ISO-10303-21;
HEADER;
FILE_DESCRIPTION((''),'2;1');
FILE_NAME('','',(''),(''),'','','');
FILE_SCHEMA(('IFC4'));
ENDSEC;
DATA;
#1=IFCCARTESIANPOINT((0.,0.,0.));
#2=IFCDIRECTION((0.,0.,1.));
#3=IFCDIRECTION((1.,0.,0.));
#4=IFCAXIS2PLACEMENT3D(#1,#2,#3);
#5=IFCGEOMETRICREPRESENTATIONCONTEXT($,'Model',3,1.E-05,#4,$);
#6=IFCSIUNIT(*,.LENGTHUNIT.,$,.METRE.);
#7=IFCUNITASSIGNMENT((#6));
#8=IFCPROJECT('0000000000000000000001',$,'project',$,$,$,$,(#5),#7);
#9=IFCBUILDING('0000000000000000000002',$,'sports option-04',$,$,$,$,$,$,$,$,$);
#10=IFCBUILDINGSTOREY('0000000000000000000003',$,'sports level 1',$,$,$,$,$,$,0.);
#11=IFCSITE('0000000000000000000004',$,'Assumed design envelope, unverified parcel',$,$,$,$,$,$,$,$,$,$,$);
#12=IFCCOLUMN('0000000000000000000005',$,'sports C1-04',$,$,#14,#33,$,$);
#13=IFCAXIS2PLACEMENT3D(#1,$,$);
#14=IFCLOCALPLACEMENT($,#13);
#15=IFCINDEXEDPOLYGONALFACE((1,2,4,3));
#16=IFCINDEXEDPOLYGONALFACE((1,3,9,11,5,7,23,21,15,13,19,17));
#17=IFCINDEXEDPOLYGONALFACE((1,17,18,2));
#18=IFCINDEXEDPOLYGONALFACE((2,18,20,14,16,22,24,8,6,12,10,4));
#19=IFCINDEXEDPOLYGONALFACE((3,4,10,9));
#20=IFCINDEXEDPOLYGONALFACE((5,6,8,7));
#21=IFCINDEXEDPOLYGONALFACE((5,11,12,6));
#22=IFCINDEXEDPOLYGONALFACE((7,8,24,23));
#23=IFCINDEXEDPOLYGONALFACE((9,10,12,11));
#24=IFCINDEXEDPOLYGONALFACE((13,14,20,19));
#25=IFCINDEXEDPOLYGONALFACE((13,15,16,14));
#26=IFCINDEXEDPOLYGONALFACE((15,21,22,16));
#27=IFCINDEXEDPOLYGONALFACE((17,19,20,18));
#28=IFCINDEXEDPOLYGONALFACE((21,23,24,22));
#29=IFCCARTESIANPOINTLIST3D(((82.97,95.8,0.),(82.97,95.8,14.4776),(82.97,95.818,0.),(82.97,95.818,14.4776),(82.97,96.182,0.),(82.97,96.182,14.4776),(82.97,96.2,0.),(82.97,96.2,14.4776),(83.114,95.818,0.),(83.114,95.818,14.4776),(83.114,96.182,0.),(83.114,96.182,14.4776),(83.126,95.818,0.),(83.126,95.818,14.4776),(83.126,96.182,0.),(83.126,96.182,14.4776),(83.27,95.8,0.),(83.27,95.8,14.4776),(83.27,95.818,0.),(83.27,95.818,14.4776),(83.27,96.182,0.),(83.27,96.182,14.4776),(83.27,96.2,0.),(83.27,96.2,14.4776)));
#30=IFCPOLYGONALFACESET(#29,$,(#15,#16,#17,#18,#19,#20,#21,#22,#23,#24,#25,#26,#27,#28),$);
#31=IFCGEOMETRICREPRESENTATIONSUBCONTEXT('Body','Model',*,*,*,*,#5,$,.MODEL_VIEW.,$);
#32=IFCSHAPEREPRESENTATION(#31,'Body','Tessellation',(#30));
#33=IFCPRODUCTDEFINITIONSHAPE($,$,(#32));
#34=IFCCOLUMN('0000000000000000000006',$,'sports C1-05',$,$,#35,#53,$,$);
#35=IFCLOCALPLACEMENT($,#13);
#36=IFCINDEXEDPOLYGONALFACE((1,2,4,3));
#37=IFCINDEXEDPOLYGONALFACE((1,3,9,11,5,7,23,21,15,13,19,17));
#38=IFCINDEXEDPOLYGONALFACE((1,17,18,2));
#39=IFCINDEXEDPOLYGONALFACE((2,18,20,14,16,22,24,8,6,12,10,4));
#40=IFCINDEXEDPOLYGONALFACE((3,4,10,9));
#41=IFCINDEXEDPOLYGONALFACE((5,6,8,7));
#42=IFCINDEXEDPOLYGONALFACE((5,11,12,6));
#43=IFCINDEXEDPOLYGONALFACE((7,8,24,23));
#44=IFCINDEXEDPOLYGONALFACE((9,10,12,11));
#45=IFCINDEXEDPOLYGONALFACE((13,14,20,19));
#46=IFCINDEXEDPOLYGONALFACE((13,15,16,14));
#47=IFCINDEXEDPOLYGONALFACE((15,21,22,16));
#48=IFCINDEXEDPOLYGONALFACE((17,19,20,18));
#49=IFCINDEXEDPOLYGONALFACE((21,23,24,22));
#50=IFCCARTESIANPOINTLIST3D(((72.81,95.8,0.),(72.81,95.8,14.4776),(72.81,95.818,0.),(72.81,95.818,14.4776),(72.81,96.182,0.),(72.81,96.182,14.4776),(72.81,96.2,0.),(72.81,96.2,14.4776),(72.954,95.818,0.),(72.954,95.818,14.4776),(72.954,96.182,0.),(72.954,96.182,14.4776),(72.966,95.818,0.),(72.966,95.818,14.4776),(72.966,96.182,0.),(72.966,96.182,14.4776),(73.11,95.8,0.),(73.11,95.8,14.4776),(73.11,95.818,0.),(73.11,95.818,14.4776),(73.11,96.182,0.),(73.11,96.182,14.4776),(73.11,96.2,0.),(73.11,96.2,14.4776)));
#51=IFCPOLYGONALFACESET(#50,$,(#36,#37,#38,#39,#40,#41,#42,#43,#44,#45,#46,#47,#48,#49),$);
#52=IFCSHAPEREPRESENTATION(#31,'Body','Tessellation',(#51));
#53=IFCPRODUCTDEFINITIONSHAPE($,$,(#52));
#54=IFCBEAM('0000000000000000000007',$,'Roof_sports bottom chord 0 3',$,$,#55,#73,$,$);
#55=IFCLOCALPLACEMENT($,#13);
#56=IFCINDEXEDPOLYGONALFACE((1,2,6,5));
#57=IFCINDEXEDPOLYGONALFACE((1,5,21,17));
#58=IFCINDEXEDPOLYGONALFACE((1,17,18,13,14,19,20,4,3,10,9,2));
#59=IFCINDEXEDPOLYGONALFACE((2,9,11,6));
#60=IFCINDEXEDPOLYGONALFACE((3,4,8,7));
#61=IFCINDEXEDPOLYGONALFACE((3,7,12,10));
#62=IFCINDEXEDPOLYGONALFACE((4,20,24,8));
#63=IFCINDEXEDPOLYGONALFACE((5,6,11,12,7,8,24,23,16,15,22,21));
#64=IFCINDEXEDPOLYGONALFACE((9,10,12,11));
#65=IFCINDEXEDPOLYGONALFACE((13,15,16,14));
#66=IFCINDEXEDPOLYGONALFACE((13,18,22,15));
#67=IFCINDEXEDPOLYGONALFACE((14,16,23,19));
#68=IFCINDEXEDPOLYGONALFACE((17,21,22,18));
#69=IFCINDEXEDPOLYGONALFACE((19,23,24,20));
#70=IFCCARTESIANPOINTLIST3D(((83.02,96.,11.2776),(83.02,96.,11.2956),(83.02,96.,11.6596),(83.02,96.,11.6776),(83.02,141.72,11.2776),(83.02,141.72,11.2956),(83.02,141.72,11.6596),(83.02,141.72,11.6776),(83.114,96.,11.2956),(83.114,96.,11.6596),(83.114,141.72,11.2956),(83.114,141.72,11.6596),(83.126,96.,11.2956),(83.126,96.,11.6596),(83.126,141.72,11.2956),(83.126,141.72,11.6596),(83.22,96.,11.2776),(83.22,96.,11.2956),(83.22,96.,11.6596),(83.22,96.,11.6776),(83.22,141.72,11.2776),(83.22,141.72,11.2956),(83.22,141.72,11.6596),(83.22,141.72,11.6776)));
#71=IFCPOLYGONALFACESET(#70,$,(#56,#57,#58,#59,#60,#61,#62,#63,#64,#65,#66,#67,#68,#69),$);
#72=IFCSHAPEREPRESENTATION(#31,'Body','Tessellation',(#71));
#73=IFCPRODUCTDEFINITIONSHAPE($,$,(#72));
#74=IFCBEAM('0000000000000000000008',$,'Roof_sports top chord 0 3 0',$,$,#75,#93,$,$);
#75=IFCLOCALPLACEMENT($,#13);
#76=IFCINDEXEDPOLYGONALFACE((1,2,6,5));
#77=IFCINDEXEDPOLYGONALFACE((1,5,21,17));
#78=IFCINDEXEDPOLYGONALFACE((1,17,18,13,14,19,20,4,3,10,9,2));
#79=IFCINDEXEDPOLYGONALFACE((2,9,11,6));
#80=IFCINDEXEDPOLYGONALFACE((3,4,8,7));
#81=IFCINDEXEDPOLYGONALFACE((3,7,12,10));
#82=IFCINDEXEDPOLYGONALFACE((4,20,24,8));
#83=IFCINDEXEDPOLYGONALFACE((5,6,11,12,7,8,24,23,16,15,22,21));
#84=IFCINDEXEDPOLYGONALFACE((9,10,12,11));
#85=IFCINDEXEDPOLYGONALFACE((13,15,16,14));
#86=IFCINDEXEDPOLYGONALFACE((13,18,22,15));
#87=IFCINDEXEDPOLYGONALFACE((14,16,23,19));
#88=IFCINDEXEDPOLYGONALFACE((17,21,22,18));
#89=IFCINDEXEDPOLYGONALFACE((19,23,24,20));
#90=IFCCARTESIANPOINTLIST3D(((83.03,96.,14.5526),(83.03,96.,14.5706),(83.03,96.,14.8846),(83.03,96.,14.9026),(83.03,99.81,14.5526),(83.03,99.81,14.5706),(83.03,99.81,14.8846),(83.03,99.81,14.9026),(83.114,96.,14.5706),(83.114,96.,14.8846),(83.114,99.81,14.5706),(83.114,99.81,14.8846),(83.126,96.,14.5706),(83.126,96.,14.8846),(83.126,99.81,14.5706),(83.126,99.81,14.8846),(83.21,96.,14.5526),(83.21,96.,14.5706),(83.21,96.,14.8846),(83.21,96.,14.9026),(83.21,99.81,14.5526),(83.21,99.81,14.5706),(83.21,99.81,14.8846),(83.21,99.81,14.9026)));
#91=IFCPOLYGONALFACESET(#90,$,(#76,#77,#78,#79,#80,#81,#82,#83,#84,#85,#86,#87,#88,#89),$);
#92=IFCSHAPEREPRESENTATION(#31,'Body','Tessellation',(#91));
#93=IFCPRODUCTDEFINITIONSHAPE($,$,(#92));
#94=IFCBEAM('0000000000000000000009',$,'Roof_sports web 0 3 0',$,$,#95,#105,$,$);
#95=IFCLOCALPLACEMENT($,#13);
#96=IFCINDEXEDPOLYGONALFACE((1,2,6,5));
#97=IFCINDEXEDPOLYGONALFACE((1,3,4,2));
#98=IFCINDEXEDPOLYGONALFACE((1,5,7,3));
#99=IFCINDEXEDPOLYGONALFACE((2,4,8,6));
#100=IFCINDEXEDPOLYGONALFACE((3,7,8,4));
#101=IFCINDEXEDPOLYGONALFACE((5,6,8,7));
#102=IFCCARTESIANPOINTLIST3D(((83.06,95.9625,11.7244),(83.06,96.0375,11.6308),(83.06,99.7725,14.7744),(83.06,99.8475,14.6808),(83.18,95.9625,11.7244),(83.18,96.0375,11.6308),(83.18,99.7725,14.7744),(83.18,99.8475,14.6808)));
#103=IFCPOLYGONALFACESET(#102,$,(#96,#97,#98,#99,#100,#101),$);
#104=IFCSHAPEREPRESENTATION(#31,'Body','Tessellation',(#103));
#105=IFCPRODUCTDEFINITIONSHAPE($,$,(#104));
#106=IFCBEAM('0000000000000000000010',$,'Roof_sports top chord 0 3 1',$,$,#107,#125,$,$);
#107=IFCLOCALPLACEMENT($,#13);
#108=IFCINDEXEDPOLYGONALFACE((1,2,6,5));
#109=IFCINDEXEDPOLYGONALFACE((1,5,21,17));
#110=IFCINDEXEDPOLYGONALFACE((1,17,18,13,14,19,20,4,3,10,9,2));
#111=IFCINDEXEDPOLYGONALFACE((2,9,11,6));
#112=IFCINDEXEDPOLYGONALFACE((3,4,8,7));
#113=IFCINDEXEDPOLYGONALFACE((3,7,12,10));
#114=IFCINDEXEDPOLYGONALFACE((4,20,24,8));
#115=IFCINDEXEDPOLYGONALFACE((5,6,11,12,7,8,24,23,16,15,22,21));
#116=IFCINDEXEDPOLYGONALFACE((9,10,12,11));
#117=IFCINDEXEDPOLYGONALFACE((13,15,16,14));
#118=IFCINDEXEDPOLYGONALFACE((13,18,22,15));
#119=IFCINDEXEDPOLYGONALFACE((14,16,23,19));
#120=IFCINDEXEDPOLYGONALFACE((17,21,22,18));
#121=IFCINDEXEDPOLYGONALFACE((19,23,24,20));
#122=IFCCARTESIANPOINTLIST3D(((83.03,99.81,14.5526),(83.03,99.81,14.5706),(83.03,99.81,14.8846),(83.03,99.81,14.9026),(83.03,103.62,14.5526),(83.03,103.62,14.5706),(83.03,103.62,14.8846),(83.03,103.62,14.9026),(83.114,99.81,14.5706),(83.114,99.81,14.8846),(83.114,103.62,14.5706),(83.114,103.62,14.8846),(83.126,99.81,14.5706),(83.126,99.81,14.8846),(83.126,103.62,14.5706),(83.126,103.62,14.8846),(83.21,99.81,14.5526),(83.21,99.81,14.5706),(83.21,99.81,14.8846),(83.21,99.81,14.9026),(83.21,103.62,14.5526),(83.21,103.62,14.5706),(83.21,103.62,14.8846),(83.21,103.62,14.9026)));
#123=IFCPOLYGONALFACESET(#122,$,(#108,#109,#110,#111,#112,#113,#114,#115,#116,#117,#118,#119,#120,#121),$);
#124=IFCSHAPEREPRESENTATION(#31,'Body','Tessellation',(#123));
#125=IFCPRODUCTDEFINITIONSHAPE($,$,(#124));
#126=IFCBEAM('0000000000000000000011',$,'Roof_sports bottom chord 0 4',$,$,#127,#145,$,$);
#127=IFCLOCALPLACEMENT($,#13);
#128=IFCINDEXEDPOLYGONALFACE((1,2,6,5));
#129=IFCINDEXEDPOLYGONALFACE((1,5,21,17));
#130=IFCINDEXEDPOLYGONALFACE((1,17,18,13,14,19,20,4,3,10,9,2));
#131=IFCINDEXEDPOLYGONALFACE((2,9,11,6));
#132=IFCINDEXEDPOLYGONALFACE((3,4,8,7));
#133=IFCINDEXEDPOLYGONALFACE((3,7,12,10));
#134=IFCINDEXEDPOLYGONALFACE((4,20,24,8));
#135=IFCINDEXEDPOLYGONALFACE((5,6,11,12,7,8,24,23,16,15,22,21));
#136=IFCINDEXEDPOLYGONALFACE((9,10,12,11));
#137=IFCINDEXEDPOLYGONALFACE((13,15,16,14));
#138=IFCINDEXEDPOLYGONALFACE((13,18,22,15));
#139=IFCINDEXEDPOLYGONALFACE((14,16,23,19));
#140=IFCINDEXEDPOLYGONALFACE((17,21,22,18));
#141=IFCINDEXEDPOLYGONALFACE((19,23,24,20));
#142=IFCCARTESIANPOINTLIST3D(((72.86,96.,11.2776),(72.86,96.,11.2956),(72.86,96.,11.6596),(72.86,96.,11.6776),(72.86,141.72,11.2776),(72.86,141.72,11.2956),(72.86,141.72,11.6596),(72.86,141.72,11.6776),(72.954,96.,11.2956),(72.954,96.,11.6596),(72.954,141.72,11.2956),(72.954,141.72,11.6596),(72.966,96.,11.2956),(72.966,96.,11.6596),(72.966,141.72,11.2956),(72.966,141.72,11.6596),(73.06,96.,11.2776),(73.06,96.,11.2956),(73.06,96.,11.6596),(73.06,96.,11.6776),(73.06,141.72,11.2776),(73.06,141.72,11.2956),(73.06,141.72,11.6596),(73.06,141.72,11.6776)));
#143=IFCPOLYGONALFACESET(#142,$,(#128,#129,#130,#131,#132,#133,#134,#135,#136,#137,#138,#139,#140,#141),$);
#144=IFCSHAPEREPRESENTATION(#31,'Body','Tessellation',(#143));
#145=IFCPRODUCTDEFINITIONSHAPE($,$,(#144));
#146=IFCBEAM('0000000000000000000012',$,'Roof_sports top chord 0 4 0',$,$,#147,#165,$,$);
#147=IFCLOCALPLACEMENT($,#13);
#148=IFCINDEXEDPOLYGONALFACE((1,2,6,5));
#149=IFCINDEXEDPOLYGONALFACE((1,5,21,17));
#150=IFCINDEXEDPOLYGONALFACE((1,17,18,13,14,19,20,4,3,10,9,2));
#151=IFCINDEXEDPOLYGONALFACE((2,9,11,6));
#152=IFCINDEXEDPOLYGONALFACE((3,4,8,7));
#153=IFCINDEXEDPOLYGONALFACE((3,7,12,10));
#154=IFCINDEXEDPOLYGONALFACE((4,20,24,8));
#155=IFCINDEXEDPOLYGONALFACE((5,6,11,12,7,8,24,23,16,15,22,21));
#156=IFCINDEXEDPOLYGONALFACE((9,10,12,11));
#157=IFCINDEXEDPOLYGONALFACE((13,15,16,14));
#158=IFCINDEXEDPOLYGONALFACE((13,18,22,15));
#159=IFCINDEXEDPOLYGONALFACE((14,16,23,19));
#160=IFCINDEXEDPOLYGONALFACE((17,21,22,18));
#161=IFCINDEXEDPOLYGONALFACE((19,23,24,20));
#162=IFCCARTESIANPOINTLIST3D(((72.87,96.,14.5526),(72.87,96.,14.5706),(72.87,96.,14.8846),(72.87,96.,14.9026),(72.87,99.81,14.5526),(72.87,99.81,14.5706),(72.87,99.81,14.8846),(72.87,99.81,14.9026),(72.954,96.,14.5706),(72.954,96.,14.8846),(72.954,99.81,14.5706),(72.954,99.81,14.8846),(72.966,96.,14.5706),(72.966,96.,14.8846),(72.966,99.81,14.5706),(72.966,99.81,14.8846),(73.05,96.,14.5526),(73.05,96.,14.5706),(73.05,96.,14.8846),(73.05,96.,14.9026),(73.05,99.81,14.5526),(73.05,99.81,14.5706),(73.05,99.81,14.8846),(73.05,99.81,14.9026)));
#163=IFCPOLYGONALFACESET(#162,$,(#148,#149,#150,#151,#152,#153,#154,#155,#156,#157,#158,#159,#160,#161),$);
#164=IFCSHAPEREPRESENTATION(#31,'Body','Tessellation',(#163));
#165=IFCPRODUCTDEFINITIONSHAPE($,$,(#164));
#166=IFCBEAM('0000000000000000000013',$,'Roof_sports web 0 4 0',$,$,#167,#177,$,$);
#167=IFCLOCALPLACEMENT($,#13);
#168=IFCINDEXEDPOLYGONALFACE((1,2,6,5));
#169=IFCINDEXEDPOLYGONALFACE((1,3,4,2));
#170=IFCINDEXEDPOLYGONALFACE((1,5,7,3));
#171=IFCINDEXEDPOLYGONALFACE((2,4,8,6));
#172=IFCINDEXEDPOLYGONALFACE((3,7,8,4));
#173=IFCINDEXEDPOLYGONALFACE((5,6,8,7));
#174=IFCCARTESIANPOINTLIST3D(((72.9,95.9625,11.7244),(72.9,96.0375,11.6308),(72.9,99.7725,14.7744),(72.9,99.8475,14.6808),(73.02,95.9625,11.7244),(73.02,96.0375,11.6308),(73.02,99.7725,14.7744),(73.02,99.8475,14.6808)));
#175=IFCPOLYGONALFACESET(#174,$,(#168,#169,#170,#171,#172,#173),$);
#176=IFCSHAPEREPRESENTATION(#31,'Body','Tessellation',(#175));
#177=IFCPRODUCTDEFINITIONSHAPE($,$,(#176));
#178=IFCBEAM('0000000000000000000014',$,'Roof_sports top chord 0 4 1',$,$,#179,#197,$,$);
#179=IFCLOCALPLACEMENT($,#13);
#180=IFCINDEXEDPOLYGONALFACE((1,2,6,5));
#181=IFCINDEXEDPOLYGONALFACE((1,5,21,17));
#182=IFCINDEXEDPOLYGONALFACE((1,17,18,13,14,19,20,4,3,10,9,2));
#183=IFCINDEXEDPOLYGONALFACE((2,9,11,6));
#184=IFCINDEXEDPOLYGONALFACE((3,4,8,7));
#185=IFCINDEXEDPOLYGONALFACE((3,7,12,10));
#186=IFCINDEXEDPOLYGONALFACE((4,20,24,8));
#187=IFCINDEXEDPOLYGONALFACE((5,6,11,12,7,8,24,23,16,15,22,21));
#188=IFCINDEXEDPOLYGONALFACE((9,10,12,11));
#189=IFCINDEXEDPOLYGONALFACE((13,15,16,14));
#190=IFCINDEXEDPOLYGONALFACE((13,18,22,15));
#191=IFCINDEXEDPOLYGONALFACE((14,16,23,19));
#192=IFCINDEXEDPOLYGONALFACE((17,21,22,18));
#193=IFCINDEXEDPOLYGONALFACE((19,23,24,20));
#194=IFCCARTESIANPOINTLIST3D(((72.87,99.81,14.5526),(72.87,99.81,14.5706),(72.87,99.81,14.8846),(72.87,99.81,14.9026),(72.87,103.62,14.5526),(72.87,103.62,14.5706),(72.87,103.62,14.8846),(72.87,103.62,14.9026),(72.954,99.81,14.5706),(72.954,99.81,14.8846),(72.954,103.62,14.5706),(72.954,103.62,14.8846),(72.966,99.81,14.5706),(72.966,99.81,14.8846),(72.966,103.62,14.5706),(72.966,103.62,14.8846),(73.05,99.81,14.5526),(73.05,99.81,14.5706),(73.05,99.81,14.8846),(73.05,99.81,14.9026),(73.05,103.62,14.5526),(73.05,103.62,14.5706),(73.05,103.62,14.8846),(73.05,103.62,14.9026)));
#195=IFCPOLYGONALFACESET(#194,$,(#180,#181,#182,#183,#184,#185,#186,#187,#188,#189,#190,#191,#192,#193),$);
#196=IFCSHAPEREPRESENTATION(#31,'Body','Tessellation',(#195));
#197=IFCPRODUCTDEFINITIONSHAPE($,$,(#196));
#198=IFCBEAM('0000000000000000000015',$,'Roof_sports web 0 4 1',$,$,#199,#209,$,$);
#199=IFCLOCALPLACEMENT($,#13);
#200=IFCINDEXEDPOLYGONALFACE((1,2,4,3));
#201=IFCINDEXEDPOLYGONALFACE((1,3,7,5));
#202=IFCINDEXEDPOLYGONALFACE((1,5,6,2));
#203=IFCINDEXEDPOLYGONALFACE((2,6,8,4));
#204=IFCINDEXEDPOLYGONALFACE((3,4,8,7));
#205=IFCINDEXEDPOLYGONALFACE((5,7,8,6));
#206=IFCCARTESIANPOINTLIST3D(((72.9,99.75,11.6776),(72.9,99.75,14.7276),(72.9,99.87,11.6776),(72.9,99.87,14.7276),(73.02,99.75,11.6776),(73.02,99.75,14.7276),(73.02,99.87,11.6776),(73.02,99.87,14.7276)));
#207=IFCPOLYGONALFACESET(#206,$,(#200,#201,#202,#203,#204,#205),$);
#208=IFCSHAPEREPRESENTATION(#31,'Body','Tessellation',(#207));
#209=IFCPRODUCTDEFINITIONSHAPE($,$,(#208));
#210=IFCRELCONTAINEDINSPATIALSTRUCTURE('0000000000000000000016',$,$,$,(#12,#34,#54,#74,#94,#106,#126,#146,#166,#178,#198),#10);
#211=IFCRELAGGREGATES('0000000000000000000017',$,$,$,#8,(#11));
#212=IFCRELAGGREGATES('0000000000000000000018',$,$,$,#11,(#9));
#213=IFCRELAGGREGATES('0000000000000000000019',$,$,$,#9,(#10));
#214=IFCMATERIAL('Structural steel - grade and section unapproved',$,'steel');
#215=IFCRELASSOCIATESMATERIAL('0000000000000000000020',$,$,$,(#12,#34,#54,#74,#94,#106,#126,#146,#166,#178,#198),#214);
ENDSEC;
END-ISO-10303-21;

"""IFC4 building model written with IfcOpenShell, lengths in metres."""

from ifc_helpers import new_model, si_unit, frame, origin_with_axes, place, context, subcontext, project, spatial, rectangle, i_section, extrude, material, element, save


model = new_model("IFC4")

# Units and contexts
model_context = context("Model", 3, precision=1e-05, world=origin_with_axes())
body_context = subcontext(model_context, "Body", "Model", "MODEL_VIEW")
ifc_project = project(units=[si_unit("LENGTHUNIT", "METRE")], contexts=[model_context])

# Site, building, storey
site = spatial("IfcSite", under=ifc_project, Name="Assumed design envelope, unverified parcel")
building = spatial("IfcBuilding", under=site, Name="sports option-04")
storey = spatial("IfcBuildingStorey", under=building, Name="sports level 1", Elevation=0.0)

# Columns
ifc_material_1 = material(Name="Structural steel - grade and section unapproved", Category="steel")
for number, where, z_axis, x_axis, name in (
    (1, (83.12, 96.0, 0.0), (0.0, 0.0, 1.0), (-1.0, 0.0, 0.0), "sports C1-04"),
    (2, (72.96, 96.0, 0.0), (0.0, 0.0, 1.0), (-1.0, 0.0, 0.0), "sports C1-05"),
):
    element("IfcColumn", number, at=place(None, frame(where, z_axis=z_axis, x_axis=x_axis)), inside=storey, material=ifc_material_1, Name=name, context=body_context, shape_type="SweptSolid", body=[
        extrude(i_section(OverallWidth=0.3, OverallDepth=0.4, WebThickness=0.012, FlangeThickness=0.018, FilletRadius=0.0), origin_with_axes(), (0.0, 0.0, 1.0), 14.4776),
    ])

# Beams
beam_1_placement = place(None, frame((83.12, 96.0, 11.4776), z_axis=(0.0, 1.0, 0.0), x_axis=(-1.0, 0.0, 0.0)))
element("IfcBeam", 3, at=beam_1_placement, inside=storey, material=ifc_material_1, Name="Roof_sports bottom chord 0 3", context=body_context, shape_type="SweptSolid", body=[
    extrude(i_section(OverallWidth=0.2, OverallDepth=0.4, WebThickness=0.012, FlangeThickness=0.018, FilletRadius=0.0), origin_with_axes(), (0.0, 0.0, 1.0), 45.72),
])
beam_2_placement = place(None, frame((83.12, 96.0, 14.7276), z_axis=(0.0, 1.0, 0.0), x_axis=(-1.0, 0.0, 0.0)))
element("IfcBeam", 4, at=beam_2_placement, inside=storey, material=ifc_material_1, Name="Roof_sports top chord 0 3 0", context=body_context, shape_type="SweptSolid", body=[
    extrude(i_section(OverallWidth=0.18, OverallDepth=0.35, WebThickness=0.012, FlangeThickness=0.018, FilletRadius=0.0), origin_with_axes(), (0.0, 0.0, 1.0), 3.81),
])
beam_3_placement = place(None, frame((83.12, 96.0, 11.6776), z_axis=(0.0, 0.780669, 0.624945), x_axis=(-1.0, 0.0, 0.0)))
element("IfcBeam", 5, at=beam_3_placement, inside=storey, material=ifc_material_1, Name="Roof_sports web 0 3 0", context=body_context, shape_type="SweptSolid", body=[
    extrude(rectangle(XDim=0.12, YDim=0.12), origin_with_axes(), (0.0, 0.0, 1.0), 4.8804),
])
beam_4_placement = place(None, frame((83.12, 99.81, 14.7276), z_axis=(0.0, 1.0, 0.0), x_axis=(-1.0, 0.0, 0.0)))
element("IfcBeam", 6, at=beam_4_placement, inside=storey, material=ifc_material_1, Name="Roof_sports top chord 0 3 1", context=body_context, shape_type="SweptSolid", body=[
    extrude(i_section(OverallWidth=0.18, OverallDepth=0.35, WebThickness=0.012, FlangeThickness=0.018, FilletRadius=0.0), origin_with_axes(), (0.0, 0.0, 1.0), 3.81),
])
beam_5_placement = place(None, frame((72.96, 96.0, 11.4776), z_axis=(0.0, 1.0, 0.0), x_axis=(-1.0, 0.0, 0.0)))
element("IfcBeam", 7, at=beam_5_placement, inside=storey, material=ifc_material_1, Name="Roof_sports bottom chord 0 4", context=body_context, shape_type="SweptSolid", body=[
    extrude(i_section(OverallWidth=0.2, OverallDepth=0.4, WebThickness=0.012, FlangeThickness=0.018, FilletRadius=0.0), origin_with_axes(), (0.0, 0.0, 1.0), 45.72),
])
beam_6_placement = place(None, frame((72.96, 96.0, 14.7276), z_axis=(0.0, 1.0, 0.0), x_axis=(-1.0, 0.0, 0.0)))
element("IfcBeam", 8, at=beam_6_placement, inside=storey, material=ifc_material_1, Name="Roof_sports top chord 0 4 0", context=body_context, shape_type="SweptSolid", body=[
    extrude(i_section(OverallWidth=0.18, OverallDepth=0.35, WebThickness=0.012, FlangeThickness=0.018, FilletRadius=0.0), origin_with_axes(), (0.0, 0.0, 1.0), 3.81),
])
beam_7_placement = place(None, frame((72.96, 96.0, 11.6776), z_axis=(0.0, 0.780669, 0.624945), x_axis=(-1.0, 0.0, 0.0)))
element("IfcBeam", 9, at=beam_7_placement, inside=storey, material=ifc_material_1, Name="Roof_sports web 0 4 0", context=body_context, shape_type="SweptSolid", body=[
    extrude(rectangle(XDim=0.12, YDim=0.12), origin_with_axes(), (0.0, 0.0, 1.0), 4.8804),
])
beam_8_placement = place(None, frame((72.96, 99.81, 14.7276), z_axis=(0.0, 1.0, 0.0), x_axis=(-1.0, 0.0, 0.0)))
element("IfcBeam", 10, at=beam_8_placement, inside=storey, material=ifc_material_1, Name="Roof_sports top chord 0 4 1", context=body_context, shape_type="SweptSolid", body=[
    extrude(i_section(OverallWidth=0.18, OverallDepth=0.35, WebThickness=0.012, FlangeThickness=0.018, FilletRadius=0.0), origin_with_axes(), (0.0, 0.0, 1.0), 3.81),
])
beam_9_placement = place(None, frame((72.96, 99.81, 11.6776), z_axis=(0.0, 0.0, 1.0), x_axis=(-1.0, 0.0, 0.0)))
element("IfcBeam", 11, at=beam_9_placement, inside=storey, material=ifc_material_1, Name="Roof_sports web 0 4 1", context=body_context, shape_type="SweptSolid", body=[
    extrude(rectangle(XDim=0.12, YDim=0.12), origin_with_axes(), (0.0, 0.0, 1.0), 3.05),
])

save(model, "model.ifc")
